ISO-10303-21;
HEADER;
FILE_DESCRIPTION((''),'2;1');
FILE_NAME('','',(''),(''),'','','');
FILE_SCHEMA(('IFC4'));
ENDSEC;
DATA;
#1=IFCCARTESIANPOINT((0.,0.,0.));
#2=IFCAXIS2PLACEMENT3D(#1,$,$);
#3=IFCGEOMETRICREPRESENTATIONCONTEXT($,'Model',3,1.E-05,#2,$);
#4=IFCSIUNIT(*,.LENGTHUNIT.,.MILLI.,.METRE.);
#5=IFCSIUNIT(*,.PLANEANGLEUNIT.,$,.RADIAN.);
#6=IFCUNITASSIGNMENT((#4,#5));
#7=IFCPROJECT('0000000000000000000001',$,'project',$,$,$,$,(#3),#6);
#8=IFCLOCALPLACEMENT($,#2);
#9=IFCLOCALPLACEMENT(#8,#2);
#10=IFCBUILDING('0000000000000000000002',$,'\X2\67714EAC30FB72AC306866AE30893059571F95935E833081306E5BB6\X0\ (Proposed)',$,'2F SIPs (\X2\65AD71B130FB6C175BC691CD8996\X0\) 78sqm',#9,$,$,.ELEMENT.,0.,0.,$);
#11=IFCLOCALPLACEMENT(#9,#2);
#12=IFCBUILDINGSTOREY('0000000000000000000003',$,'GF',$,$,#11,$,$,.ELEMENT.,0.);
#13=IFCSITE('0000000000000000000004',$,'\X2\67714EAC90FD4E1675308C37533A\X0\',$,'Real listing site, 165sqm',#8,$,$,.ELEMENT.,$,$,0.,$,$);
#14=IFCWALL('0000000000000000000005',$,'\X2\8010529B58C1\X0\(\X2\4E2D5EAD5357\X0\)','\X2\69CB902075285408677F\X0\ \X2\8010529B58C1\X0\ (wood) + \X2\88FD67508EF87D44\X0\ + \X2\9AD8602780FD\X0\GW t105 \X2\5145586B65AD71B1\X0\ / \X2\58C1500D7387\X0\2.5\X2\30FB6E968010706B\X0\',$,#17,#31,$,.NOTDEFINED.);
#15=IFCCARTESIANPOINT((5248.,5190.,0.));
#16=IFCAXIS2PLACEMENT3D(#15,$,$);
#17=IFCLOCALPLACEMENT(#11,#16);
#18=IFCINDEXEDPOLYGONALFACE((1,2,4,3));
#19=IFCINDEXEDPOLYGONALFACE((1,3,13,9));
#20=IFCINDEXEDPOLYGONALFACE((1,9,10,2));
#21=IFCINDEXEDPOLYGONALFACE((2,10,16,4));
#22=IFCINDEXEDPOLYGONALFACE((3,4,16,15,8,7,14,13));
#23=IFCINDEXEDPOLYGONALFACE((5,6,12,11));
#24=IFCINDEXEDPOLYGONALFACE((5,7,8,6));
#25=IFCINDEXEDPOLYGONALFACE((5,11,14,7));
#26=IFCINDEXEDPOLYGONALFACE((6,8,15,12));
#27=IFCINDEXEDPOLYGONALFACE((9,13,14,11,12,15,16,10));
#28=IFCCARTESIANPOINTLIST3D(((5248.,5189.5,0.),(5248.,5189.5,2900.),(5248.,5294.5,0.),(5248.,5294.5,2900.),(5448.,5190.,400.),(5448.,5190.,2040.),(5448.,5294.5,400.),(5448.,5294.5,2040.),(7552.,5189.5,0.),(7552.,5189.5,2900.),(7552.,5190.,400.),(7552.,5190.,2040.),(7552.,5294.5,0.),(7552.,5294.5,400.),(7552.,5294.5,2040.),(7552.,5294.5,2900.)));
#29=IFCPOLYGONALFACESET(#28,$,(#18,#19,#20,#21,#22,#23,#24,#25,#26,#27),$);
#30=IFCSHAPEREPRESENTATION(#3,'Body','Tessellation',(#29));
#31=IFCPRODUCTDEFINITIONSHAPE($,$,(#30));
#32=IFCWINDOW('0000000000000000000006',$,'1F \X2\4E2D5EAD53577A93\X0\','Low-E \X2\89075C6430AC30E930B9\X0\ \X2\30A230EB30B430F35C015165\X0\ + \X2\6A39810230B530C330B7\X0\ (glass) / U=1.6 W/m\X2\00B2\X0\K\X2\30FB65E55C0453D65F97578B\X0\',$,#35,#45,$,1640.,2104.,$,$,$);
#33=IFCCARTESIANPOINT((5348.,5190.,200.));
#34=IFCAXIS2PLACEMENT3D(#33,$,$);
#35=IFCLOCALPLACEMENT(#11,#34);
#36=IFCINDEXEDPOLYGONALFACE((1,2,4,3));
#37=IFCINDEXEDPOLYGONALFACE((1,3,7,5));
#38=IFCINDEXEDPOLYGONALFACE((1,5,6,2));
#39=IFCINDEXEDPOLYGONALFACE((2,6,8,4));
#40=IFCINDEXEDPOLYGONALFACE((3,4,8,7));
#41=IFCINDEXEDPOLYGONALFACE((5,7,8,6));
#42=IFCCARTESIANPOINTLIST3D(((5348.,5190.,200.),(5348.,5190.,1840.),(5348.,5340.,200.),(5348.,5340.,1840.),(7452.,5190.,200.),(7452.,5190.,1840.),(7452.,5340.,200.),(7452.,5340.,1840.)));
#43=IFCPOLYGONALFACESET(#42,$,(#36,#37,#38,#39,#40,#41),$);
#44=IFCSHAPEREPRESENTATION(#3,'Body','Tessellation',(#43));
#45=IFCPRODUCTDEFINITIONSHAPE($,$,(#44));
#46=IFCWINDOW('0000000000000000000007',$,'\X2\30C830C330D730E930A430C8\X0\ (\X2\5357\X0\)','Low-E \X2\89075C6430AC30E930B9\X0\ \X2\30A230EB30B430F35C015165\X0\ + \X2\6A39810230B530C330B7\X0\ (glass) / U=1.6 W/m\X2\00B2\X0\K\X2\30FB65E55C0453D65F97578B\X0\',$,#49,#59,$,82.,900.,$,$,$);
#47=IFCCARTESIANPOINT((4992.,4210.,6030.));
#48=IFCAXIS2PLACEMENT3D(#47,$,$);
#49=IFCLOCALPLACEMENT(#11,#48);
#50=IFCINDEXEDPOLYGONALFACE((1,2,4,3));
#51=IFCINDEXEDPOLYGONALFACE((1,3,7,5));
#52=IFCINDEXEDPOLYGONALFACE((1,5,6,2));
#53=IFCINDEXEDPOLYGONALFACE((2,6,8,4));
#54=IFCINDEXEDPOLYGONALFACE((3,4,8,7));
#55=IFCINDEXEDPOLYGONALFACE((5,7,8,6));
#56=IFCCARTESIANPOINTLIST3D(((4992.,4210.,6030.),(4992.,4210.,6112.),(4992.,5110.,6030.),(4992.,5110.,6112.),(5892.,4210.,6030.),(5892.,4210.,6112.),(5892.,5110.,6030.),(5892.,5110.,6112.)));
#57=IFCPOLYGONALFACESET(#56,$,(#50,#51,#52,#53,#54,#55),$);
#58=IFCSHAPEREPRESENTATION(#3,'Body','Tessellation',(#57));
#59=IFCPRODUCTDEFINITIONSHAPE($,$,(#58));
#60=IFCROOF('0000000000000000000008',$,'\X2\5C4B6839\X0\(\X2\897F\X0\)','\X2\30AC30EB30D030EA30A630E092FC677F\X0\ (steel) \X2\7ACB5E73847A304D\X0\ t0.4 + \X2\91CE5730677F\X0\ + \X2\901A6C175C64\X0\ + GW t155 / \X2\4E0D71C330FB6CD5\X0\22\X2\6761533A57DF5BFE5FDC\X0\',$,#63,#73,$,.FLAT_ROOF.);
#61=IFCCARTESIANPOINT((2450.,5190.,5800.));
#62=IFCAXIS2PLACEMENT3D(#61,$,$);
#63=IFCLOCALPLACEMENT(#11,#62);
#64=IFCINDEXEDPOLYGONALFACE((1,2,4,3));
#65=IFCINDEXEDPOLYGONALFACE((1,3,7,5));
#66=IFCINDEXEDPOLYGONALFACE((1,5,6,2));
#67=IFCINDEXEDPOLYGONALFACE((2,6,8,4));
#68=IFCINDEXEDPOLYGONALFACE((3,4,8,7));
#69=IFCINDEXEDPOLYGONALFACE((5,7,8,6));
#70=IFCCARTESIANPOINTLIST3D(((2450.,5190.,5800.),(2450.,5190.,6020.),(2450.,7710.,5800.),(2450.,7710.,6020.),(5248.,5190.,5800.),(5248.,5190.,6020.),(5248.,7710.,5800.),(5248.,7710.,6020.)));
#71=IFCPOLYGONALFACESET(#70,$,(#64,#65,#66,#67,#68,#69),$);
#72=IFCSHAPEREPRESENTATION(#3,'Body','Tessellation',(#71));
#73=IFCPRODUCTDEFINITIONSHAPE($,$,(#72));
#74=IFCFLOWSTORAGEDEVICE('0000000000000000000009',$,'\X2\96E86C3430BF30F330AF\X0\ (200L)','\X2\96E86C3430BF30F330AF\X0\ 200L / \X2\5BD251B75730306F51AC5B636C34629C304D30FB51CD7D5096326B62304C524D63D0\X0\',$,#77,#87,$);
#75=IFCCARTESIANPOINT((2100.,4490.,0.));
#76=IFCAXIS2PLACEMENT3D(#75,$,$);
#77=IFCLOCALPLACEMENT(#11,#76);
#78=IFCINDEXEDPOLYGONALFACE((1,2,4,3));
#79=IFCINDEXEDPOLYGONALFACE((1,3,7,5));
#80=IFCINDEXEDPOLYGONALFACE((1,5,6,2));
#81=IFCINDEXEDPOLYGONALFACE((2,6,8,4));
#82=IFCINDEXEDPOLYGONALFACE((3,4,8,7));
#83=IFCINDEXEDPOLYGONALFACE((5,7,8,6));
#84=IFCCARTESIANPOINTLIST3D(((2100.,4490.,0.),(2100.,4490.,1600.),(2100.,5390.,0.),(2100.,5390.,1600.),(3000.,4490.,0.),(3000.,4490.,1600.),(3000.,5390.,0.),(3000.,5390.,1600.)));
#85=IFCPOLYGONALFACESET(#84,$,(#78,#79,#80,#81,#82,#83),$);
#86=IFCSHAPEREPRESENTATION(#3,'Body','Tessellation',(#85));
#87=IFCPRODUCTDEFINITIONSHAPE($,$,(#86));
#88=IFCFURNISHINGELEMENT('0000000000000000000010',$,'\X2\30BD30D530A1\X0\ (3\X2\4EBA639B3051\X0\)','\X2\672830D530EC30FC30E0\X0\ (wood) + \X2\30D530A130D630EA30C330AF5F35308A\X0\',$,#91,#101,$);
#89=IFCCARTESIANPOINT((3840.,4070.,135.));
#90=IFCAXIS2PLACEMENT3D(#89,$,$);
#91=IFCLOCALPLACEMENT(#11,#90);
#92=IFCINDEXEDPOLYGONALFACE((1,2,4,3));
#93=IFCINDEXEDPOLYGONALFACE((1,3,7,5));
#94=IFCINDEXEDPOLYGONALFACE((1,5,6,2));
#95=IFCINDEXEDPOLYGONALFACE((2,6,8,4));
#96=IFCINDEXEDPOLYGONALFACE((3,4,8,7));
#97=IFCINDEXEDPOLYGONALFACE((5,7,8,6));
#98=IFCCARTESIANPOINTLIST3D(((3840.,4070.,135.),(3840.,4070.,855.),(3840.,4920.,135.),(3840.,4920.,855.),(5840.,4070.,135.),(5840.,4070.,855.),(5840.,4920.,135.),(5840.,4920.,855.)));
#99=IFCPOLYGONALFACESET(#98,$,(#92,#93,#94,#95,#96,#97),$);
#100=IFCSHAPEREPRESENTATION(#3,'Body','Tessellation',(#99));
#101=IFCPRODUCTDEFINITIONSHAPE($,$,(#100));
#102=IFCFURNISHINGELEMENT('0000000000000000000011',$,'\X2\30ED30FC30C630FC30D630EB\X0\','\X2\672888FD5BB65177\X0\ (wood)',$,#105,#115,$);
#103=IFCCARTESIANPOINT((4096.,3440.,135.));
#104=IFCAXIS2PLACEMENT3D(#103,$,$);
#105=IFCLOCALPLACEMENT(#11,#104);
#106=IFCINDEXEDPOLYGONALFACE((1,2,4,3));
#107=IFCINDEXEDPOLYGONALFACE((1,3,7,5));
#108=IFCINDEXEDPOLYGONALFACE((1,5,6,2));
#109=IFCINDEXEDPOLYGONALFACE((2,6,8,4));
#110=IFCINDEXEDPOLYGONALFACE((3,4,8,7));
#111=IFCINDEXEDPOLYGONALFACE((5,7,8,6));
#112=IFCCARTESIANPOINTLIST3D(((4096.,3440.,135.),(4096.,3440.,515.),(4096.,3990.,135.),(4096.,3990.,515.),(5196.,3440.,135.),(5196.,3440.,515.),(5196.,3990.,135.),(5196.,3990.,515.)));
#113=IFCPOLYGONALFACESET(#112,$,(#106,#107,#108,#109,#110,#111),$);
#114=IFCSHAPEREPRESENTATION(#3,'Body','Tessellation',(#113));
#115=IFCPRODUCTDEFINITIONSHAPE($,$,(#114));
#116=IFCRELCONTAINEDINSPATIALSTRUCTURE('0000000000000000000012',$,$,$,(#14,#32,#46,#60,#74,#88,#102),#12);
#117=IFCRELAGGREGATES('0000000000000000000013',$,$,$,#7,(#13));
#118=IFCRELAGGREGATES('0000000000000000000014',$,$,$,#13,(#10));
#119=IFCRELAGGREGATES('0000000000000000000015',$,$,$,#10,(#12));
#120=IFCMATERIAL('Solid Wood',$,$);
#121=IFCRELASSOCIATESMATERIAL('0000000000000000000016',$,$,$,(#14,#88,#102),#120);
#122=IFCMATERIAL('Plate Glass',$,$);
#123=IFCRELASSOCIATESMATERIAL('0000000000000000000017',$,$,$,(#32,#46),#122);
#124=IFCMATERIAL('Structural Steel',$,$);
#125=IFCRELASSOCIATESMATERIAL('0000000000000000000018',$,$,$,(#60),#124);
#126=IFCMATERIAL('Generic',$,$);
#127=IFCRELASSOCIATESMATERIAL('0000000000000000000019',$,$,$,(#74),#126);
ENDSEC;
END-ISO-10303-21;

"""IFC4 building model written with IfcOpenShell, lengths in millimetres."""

from ifc_helpers import new_model, si_unit, frame, frame_2d, origin, place, context, project, spatial, rectangle, extrude, material, element, fill, save


model = new_model("IFC4")

# Units and contexts
model_context = context("Model", 3, precision=1e-05, world=origin())
ifc_project = project(units=[si_unit("LENGTHUNIT", "METRE", prefix="MILLI"), si_unit("PLANEANGLEUNIT", "RADIAN")], contexts=[model_context])

# Site, building, storey
site_placement = place(None, origin())
site = spatial("IfcSite", under=ifc_project, at=site_placement, Name="東京都世田谷区", ObjectType="Real listing site, 165sqm", CompositionType="ELEMENT", RefElevation=0.0)
building_placement = place(site_placement, origin())
building = spatial("IfcBuilding", under=site, at=building_placement, Name="東京・犬と暮らす土間広めの家 (Proposed)", ObjectType="2F SIPs (断熱・気密重視) 78sqm", CompositionType="ELEMENT", ElevationOfRefHeight=0.0, ElevationOfTerrain=0.0)
storey_placement = place(building_placement, origin())
storey = spatial("IfcBuildingStorey", under=building, at=storey_placement, Name="GF", CompositionType="ELEMENT", Elevation=0.0)

# Shared definitions
ifc_material_1 = material(Name="Solid Wood")

# Wall, opening, window
wall_placement = place(storey_placement, frame((5248.0, 5190.0, 0.0)))
wall = element("IfcWall", 1, at=wall_placement, inside=storey, material=ifc_material_1, Name="耐力壁(中庭南)", Description="構造用合板 耐力壁 (wood) + 製材軸組 + 高性能GW t105 充填断熱 / 壁倍率2.5・準耐火", PredefinedType="NOTDEFINED", context=model_context, shape_type="SweptSolid", body=[
    extrude(rectangle(XDim=2304.0, YDim=105.0, at=frame_2d((1152.0, 52.0))), frame((5248.0, 5190.0, 0.0)), (0.0, 0.0, 1.0), 2900.0),
])
opening_placement = place(storey_placement, frame((5348.0, 5190.0, 200.0)))
opening = element("IfcOpeningElement", 2, at=opening_placement, cuts=wall, PredefinedType="NOTDEFINED", context=model_context, shape_type="SweptSolid", body=[
    extrude(rectangle(XDim=2104.0, YDim=150.0, at=frame_2d((1052.0, 75.0))), frame((5348.0, 5190.0, 200.0)), (0.0, 0.0, 1.0), 1640.0),
])
ifc_material_2 = material(Name="Plate Glass")
window_1_placement = place(storey_placement, frame((5348.0, 5190.0, 200.0)))
window_1 = element("IfcWindow", 3, at=window_1_placement, inside=storey, material=ifc_material_2, Name="1F 中庭南窓", Description="Low-E 複層ガラス アルゴン封入 + 樹脂サッシ (glass) / U=1.6 W/m²K・日射取得型", OverallHeight=1640.0, OverallWidth=2104.0, context=model_context, shape_type="SweptSolid", body=[
    extrude(rectangle(XDim=2104.0, YDim=150.0, at=frame_2d((1052.0, 75.0))), frame((5348.0, 5190.0, 200.0)), (0.0, 0.0, 1.0), 1640.0),
])
fill(opening, window_1)

# Window
window_2_placement = place(storey_placement, frame((4992.0, 4210.0, 6030.0)))
element("IfcWindow", 4, at=window_2_placement, inside=storey, material=ifc_material_2, Name="トップライト (南)", Description="Low-E 複層ガラス アルゴン封入 + 樹脂サッシ (glass) / U=1.6 W/m²K・日射取得型", OverallHeight=82.0, OverallWidth=900.0, context=model_context, shape_type="SweptSolid", body=[
    extrude(rectangle(XDim=900.0, YDim=900.0, at=frame_2d((450.0, 450.0))), frame((4992.0, 4210.0, 6030.0)), (0.0, 0.0, 1.0), 82.0),
])

# Roof
ifc_material_3 = material(Name="Structural Steel")
for number, where, name in (
    (5, (2450.0, 5190.0, 5800.0), "屋根(西)"),
):
    element("IfcRoof", number, at=place(storey_placement, frame(where)), inside=storey, material=ifc_material_3, Name=name, Description="ガルバリウム鋼板 (steel) 立平葺き t0.4 + 野地板 + 通気層 + GW t155 / 不燃・法22条区域対応", PredefinedType="FLAT_ROOF", context=model_context, shape_type="SweptSolid", body=[
        extrude(rectangle(XDim=2798.0, YDim=2520.0, at=frame_2d((1399.0, 1260.0))), frame((2450.0, 5190.0, 5800.0)), (0.0, 0.0, 1.0), 220.0),
    ])

# Flow storage device
ifc_material_4 = material(Name="Generic")
flow_storage_device_placement = place(storey_placement, frame((2100.0, 4490.0, 0.0)))
element("IfcFlowStorageDevice", 6, at=flow_storage_device_placement, inside=storey, material=ifc_material_4, Name="雨水タンク (200L)", Description="雨水タンク 200L / 寒冷地は冬季水抜き・凍結防止が前提", context=model_context, shape_type="SweptSolid", body=[
    extrude(rectangle(XDim=900.0, YDim=900.0, at=frame_2d((450.0, 450.0))), frame((2100.0, 4490.0, 0.0)), (0.0, 0.0, 1.0), 1600.0),
])

# Furnishing elements
furnishing_1_placement = place(storey_placement, frame((3840.0, 4070.0, 135.0)))
element("IfcFurnishingElement", 7, at=furnishing_1_placement, inside=storey, material=ifc_material_1, Name="ソファ (3人掛け)", Description="木フレーム (wood) + ファブリック張り", context=model_context, shape_type="SweptSolid", body=[
    extrude(rectangle(XDim=2000.0, YDim=850.0, at=frame_2d((1000.0, 425.0))), frame((3840.0, 4070.0, 135.0)), (0.0, 0.0, 1.0), 720.0),
])
furnishing_2_placement = place(storey_placement, frame((4096.0, 3440.0, 135.0)))
element("IfcFurnishingElement", 8, at=furnishing_2_placement, inside=storey, material=ifc_material_1, Name="ローテーブル", Description="木製家具 (wood)", context=model_context, shape_type="SweptSolid", body=[
    extrude(rectangle(XDim=1100.0, YDim=550.0, at=frame_2d((550.0, 275.0))), frame((4096.0, 3440.0, 135.0)), (0.0, 0.0, 1.0), 380.0),
])

save(model, "model.ifc")
